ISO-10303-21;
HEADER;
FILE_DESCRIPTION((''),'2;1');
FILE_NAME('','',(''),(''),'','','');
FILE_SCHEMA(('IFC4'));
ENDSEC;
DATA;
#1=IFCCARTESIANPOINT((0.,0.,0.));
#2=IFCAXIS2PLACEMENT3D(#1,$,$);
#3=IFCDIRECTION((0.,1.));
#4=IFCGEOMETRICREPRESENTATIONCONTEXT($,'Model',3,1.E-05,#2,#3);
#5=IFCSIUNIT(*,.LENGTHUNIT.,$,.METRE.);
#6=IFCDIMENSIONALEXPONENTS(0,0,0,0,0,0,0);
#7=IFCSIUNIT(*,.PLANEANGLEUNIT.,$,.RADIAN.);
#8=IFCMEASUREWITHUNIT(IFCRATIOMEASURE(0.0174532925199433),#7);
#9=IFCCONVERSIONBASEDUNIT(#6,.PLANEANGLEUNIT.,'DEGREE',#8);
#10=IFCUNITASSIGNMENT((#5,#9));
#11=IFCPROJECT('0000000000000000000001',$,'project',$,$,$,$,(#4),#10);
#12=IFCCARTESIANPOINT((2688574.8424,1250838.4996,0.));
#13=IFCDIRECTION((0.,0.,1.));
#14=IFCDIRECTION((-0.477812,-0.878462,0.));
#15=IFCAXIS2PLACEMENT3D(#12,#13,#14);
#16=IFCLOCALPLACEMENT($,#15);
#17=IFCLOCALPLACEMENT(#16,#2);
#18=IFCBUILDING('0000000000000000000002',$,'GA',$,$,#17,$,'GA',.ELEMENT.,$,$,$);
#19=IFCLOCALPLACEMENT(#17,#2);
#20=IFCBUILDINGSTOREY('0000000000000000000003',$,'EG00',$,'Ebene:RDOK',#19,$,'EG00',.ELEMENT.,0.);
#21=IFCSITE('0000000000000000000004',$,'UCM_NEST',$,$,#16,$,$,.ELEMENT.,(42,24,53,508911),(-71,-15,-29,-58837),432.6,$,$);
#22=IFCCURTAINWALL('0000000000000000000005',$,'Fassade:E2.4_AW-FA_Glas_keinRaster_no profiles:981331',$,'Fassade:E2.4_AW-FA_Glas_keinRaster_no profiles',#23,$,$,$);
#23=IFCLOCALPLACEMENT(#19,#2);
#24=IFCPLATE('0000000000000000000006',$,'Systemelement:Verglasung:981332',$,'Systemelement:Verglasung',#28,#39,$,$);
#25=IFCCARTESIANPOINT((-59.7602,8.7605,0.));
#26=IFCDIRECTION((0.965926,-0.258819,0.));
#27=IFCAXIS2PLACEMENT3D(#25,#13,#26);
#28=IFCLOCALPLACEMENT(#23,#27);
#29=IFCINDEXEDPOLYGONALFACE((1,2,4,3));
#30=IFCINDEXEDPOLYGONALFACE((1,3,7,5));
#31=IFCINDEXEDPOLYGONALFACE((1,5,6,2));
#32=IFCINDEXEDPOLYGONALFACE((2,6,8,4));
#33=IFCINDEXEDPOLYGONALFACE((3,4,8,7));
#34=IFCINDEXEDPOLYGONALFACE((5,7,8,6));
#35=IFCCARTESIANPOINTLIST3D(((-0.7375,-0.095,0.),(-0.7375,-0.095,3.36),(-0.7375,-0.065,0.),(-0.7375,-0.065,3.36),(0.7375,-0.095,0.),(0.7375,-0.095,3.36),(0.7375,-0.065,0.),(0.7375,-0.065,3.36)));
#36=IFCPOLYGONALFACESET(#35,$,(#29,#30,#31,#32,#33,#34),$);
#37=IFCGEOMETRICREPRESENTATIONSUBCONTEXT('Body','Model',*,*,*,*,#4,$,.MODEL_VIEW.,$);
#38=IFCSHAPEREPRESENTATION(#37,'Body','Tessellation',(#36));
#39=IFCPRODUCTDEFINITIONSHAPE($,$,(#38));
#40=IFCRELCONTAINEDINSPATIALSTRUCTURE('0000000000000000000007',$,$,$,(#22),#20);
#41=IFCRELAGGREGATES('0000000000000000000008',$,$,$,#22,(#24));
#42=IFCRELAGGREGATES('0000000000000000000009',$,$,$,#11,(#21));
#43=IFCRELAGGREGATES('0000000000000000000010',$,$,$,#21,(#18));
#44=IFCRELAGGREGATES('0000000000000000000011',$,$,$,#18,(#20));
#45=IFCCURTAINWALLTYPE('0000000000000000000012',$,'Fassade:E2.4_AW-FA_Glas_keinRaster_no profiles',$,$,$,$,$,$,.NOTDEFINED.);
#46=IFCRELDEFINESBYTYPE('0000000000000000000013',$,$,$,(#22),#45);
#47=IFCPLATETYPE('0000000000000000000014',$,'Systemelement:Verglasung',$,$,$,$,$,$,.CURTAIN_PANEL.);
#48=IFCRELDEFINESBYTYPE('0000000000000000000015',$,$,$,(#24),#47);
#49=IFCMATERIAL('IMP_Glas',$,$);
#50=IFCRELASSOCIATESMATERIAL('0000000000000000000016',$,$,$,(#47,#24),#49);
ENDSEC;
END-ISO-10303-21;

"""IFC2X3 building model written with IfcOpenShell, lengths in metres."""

from ifc_helpers import new_model, entity, si_unit, converted_unit, direction, frame, frame_2d, origin, place, context, subcontext, project, spatial, rectangle, extrude, source, transform, mapped, material, type_object, type_shapes, element, aggregate, save


model = new_model("IFC2X3")

# Units and contexts
model_context = context("Model", 3, precision=1e-05, world=origin(), true_north=direction((0.0, 1.0)))
body_context = subcontext(model_context, "Body", "Model", "MODEL_VIEW")
ifc_project = project(units=[si_unit("LENGTHUNIT", "METRE"), converted_unit("PLANEANGLEUNIT", "DEGREE", entity("IfcRatioMeasure", 0.0174532925199433), si_unit("PLANEANGLEUNIT", "RADIAN"), dimensions=[0, 0, 0, 0, 0, 0, 0])], contexts=[model_context])

# Site, building, storey
site_placement = place(None, frame((2688574.8424, 1250838.4996, 0.0), z_axis=(0.0, 0.0, 1.0), x_axis=(-0.477812, -0.878462, 0.0)))
site = spatial("IfcSite", under=ifc_project, at=site_placement, Name="UCM_NEST", CompositionType="ELEMENT", RefLatitude=(42, 24, 53, 508911), RefLongitude=(-71, -15, -29, -58837), RefElevation=432.6)
building_placement = place(site_placement, origin())
building = spatial("IfcBuilding", under=site, at=building_placement, Name="GA", LongName="GA", CompositionType="ELEMENT")
storey_placement = place(building_placement, origin())
storey = spatial("IfcBuildingStorey", under=building, at=storey_placement, Name="EG00", ObjectType="Ebene:RDOK", LongName="EG00", CompositionType="ELEMENT", Elevation=0.0)

# Curtain wall, plate
curtain_wall_type = type_object("IfcCurtainWallType", Name="Fassade:E2.4_AW-FA_Glas_keinRaster_no profiles", PredefinedType="NOTDEFINED")
ifc_material_1 = material(Name="IMP_Glas")
plate_type_1 = type_object("IfcPlateType", Name="Systemelement:Verglasung", PredefinedType="CURTAIN_PANEL", material=ifc_material_1)
shared_shape_1 = source(origin(), body_context, "Body", "SweptSolid", [
    extrude(rectangle(XDim=0.03, YDim=1.475, at=frame_2d((0.0, 0.0), x_axis=(1.0, 0.0))), frame((0.0, -0.08, 0.0), z_axis=(0.0, 0.0, 1.0), x_axis=(0.0, 1.0, 0.0)), (0.0, 0.0, 1.0), 3.36),
])
type_shapes(plate_type_1, [shared_shape_1])
curtain_wall_1_placement = place(storey_placement, origin())
curtain_wall_1 = element("IfcCurtainWall", 1, at=curtain_wall_1_placement, inside=storey, type_object=curtain_wall_type, Name="Fassade:E2.4_AW-FA_Glas_keinRaster_no profiles:981331", ObjectType="Fassade:E2.4_AW-FA_Glas_keinRaster_no profiles")
plate_1_placement = place(curtain_wall_1_placement, frame((-59.7602, 8.7605, 0.0), z_axis=(0.0, 0.0, 1.0), x_axis=(0.965926, -0.258819, 0.0)))
plate_1 = element("IfcPlate", 2, at=plate_1_placement, type_object=plate_type_1, material=ifc_material_1, Name="Systemelement:Verglasung:981332", ObjectType="Systemelement:Verglasung", context=body_context, shape_type="MappedRepresentation", body=[
    mapped(shared_shape_1, transform((0.0, 0.0, 0.0), scale=1.0)),
])
aggregate(curtain_wall_1, [plate_1])

save(model, "model.ifc")
